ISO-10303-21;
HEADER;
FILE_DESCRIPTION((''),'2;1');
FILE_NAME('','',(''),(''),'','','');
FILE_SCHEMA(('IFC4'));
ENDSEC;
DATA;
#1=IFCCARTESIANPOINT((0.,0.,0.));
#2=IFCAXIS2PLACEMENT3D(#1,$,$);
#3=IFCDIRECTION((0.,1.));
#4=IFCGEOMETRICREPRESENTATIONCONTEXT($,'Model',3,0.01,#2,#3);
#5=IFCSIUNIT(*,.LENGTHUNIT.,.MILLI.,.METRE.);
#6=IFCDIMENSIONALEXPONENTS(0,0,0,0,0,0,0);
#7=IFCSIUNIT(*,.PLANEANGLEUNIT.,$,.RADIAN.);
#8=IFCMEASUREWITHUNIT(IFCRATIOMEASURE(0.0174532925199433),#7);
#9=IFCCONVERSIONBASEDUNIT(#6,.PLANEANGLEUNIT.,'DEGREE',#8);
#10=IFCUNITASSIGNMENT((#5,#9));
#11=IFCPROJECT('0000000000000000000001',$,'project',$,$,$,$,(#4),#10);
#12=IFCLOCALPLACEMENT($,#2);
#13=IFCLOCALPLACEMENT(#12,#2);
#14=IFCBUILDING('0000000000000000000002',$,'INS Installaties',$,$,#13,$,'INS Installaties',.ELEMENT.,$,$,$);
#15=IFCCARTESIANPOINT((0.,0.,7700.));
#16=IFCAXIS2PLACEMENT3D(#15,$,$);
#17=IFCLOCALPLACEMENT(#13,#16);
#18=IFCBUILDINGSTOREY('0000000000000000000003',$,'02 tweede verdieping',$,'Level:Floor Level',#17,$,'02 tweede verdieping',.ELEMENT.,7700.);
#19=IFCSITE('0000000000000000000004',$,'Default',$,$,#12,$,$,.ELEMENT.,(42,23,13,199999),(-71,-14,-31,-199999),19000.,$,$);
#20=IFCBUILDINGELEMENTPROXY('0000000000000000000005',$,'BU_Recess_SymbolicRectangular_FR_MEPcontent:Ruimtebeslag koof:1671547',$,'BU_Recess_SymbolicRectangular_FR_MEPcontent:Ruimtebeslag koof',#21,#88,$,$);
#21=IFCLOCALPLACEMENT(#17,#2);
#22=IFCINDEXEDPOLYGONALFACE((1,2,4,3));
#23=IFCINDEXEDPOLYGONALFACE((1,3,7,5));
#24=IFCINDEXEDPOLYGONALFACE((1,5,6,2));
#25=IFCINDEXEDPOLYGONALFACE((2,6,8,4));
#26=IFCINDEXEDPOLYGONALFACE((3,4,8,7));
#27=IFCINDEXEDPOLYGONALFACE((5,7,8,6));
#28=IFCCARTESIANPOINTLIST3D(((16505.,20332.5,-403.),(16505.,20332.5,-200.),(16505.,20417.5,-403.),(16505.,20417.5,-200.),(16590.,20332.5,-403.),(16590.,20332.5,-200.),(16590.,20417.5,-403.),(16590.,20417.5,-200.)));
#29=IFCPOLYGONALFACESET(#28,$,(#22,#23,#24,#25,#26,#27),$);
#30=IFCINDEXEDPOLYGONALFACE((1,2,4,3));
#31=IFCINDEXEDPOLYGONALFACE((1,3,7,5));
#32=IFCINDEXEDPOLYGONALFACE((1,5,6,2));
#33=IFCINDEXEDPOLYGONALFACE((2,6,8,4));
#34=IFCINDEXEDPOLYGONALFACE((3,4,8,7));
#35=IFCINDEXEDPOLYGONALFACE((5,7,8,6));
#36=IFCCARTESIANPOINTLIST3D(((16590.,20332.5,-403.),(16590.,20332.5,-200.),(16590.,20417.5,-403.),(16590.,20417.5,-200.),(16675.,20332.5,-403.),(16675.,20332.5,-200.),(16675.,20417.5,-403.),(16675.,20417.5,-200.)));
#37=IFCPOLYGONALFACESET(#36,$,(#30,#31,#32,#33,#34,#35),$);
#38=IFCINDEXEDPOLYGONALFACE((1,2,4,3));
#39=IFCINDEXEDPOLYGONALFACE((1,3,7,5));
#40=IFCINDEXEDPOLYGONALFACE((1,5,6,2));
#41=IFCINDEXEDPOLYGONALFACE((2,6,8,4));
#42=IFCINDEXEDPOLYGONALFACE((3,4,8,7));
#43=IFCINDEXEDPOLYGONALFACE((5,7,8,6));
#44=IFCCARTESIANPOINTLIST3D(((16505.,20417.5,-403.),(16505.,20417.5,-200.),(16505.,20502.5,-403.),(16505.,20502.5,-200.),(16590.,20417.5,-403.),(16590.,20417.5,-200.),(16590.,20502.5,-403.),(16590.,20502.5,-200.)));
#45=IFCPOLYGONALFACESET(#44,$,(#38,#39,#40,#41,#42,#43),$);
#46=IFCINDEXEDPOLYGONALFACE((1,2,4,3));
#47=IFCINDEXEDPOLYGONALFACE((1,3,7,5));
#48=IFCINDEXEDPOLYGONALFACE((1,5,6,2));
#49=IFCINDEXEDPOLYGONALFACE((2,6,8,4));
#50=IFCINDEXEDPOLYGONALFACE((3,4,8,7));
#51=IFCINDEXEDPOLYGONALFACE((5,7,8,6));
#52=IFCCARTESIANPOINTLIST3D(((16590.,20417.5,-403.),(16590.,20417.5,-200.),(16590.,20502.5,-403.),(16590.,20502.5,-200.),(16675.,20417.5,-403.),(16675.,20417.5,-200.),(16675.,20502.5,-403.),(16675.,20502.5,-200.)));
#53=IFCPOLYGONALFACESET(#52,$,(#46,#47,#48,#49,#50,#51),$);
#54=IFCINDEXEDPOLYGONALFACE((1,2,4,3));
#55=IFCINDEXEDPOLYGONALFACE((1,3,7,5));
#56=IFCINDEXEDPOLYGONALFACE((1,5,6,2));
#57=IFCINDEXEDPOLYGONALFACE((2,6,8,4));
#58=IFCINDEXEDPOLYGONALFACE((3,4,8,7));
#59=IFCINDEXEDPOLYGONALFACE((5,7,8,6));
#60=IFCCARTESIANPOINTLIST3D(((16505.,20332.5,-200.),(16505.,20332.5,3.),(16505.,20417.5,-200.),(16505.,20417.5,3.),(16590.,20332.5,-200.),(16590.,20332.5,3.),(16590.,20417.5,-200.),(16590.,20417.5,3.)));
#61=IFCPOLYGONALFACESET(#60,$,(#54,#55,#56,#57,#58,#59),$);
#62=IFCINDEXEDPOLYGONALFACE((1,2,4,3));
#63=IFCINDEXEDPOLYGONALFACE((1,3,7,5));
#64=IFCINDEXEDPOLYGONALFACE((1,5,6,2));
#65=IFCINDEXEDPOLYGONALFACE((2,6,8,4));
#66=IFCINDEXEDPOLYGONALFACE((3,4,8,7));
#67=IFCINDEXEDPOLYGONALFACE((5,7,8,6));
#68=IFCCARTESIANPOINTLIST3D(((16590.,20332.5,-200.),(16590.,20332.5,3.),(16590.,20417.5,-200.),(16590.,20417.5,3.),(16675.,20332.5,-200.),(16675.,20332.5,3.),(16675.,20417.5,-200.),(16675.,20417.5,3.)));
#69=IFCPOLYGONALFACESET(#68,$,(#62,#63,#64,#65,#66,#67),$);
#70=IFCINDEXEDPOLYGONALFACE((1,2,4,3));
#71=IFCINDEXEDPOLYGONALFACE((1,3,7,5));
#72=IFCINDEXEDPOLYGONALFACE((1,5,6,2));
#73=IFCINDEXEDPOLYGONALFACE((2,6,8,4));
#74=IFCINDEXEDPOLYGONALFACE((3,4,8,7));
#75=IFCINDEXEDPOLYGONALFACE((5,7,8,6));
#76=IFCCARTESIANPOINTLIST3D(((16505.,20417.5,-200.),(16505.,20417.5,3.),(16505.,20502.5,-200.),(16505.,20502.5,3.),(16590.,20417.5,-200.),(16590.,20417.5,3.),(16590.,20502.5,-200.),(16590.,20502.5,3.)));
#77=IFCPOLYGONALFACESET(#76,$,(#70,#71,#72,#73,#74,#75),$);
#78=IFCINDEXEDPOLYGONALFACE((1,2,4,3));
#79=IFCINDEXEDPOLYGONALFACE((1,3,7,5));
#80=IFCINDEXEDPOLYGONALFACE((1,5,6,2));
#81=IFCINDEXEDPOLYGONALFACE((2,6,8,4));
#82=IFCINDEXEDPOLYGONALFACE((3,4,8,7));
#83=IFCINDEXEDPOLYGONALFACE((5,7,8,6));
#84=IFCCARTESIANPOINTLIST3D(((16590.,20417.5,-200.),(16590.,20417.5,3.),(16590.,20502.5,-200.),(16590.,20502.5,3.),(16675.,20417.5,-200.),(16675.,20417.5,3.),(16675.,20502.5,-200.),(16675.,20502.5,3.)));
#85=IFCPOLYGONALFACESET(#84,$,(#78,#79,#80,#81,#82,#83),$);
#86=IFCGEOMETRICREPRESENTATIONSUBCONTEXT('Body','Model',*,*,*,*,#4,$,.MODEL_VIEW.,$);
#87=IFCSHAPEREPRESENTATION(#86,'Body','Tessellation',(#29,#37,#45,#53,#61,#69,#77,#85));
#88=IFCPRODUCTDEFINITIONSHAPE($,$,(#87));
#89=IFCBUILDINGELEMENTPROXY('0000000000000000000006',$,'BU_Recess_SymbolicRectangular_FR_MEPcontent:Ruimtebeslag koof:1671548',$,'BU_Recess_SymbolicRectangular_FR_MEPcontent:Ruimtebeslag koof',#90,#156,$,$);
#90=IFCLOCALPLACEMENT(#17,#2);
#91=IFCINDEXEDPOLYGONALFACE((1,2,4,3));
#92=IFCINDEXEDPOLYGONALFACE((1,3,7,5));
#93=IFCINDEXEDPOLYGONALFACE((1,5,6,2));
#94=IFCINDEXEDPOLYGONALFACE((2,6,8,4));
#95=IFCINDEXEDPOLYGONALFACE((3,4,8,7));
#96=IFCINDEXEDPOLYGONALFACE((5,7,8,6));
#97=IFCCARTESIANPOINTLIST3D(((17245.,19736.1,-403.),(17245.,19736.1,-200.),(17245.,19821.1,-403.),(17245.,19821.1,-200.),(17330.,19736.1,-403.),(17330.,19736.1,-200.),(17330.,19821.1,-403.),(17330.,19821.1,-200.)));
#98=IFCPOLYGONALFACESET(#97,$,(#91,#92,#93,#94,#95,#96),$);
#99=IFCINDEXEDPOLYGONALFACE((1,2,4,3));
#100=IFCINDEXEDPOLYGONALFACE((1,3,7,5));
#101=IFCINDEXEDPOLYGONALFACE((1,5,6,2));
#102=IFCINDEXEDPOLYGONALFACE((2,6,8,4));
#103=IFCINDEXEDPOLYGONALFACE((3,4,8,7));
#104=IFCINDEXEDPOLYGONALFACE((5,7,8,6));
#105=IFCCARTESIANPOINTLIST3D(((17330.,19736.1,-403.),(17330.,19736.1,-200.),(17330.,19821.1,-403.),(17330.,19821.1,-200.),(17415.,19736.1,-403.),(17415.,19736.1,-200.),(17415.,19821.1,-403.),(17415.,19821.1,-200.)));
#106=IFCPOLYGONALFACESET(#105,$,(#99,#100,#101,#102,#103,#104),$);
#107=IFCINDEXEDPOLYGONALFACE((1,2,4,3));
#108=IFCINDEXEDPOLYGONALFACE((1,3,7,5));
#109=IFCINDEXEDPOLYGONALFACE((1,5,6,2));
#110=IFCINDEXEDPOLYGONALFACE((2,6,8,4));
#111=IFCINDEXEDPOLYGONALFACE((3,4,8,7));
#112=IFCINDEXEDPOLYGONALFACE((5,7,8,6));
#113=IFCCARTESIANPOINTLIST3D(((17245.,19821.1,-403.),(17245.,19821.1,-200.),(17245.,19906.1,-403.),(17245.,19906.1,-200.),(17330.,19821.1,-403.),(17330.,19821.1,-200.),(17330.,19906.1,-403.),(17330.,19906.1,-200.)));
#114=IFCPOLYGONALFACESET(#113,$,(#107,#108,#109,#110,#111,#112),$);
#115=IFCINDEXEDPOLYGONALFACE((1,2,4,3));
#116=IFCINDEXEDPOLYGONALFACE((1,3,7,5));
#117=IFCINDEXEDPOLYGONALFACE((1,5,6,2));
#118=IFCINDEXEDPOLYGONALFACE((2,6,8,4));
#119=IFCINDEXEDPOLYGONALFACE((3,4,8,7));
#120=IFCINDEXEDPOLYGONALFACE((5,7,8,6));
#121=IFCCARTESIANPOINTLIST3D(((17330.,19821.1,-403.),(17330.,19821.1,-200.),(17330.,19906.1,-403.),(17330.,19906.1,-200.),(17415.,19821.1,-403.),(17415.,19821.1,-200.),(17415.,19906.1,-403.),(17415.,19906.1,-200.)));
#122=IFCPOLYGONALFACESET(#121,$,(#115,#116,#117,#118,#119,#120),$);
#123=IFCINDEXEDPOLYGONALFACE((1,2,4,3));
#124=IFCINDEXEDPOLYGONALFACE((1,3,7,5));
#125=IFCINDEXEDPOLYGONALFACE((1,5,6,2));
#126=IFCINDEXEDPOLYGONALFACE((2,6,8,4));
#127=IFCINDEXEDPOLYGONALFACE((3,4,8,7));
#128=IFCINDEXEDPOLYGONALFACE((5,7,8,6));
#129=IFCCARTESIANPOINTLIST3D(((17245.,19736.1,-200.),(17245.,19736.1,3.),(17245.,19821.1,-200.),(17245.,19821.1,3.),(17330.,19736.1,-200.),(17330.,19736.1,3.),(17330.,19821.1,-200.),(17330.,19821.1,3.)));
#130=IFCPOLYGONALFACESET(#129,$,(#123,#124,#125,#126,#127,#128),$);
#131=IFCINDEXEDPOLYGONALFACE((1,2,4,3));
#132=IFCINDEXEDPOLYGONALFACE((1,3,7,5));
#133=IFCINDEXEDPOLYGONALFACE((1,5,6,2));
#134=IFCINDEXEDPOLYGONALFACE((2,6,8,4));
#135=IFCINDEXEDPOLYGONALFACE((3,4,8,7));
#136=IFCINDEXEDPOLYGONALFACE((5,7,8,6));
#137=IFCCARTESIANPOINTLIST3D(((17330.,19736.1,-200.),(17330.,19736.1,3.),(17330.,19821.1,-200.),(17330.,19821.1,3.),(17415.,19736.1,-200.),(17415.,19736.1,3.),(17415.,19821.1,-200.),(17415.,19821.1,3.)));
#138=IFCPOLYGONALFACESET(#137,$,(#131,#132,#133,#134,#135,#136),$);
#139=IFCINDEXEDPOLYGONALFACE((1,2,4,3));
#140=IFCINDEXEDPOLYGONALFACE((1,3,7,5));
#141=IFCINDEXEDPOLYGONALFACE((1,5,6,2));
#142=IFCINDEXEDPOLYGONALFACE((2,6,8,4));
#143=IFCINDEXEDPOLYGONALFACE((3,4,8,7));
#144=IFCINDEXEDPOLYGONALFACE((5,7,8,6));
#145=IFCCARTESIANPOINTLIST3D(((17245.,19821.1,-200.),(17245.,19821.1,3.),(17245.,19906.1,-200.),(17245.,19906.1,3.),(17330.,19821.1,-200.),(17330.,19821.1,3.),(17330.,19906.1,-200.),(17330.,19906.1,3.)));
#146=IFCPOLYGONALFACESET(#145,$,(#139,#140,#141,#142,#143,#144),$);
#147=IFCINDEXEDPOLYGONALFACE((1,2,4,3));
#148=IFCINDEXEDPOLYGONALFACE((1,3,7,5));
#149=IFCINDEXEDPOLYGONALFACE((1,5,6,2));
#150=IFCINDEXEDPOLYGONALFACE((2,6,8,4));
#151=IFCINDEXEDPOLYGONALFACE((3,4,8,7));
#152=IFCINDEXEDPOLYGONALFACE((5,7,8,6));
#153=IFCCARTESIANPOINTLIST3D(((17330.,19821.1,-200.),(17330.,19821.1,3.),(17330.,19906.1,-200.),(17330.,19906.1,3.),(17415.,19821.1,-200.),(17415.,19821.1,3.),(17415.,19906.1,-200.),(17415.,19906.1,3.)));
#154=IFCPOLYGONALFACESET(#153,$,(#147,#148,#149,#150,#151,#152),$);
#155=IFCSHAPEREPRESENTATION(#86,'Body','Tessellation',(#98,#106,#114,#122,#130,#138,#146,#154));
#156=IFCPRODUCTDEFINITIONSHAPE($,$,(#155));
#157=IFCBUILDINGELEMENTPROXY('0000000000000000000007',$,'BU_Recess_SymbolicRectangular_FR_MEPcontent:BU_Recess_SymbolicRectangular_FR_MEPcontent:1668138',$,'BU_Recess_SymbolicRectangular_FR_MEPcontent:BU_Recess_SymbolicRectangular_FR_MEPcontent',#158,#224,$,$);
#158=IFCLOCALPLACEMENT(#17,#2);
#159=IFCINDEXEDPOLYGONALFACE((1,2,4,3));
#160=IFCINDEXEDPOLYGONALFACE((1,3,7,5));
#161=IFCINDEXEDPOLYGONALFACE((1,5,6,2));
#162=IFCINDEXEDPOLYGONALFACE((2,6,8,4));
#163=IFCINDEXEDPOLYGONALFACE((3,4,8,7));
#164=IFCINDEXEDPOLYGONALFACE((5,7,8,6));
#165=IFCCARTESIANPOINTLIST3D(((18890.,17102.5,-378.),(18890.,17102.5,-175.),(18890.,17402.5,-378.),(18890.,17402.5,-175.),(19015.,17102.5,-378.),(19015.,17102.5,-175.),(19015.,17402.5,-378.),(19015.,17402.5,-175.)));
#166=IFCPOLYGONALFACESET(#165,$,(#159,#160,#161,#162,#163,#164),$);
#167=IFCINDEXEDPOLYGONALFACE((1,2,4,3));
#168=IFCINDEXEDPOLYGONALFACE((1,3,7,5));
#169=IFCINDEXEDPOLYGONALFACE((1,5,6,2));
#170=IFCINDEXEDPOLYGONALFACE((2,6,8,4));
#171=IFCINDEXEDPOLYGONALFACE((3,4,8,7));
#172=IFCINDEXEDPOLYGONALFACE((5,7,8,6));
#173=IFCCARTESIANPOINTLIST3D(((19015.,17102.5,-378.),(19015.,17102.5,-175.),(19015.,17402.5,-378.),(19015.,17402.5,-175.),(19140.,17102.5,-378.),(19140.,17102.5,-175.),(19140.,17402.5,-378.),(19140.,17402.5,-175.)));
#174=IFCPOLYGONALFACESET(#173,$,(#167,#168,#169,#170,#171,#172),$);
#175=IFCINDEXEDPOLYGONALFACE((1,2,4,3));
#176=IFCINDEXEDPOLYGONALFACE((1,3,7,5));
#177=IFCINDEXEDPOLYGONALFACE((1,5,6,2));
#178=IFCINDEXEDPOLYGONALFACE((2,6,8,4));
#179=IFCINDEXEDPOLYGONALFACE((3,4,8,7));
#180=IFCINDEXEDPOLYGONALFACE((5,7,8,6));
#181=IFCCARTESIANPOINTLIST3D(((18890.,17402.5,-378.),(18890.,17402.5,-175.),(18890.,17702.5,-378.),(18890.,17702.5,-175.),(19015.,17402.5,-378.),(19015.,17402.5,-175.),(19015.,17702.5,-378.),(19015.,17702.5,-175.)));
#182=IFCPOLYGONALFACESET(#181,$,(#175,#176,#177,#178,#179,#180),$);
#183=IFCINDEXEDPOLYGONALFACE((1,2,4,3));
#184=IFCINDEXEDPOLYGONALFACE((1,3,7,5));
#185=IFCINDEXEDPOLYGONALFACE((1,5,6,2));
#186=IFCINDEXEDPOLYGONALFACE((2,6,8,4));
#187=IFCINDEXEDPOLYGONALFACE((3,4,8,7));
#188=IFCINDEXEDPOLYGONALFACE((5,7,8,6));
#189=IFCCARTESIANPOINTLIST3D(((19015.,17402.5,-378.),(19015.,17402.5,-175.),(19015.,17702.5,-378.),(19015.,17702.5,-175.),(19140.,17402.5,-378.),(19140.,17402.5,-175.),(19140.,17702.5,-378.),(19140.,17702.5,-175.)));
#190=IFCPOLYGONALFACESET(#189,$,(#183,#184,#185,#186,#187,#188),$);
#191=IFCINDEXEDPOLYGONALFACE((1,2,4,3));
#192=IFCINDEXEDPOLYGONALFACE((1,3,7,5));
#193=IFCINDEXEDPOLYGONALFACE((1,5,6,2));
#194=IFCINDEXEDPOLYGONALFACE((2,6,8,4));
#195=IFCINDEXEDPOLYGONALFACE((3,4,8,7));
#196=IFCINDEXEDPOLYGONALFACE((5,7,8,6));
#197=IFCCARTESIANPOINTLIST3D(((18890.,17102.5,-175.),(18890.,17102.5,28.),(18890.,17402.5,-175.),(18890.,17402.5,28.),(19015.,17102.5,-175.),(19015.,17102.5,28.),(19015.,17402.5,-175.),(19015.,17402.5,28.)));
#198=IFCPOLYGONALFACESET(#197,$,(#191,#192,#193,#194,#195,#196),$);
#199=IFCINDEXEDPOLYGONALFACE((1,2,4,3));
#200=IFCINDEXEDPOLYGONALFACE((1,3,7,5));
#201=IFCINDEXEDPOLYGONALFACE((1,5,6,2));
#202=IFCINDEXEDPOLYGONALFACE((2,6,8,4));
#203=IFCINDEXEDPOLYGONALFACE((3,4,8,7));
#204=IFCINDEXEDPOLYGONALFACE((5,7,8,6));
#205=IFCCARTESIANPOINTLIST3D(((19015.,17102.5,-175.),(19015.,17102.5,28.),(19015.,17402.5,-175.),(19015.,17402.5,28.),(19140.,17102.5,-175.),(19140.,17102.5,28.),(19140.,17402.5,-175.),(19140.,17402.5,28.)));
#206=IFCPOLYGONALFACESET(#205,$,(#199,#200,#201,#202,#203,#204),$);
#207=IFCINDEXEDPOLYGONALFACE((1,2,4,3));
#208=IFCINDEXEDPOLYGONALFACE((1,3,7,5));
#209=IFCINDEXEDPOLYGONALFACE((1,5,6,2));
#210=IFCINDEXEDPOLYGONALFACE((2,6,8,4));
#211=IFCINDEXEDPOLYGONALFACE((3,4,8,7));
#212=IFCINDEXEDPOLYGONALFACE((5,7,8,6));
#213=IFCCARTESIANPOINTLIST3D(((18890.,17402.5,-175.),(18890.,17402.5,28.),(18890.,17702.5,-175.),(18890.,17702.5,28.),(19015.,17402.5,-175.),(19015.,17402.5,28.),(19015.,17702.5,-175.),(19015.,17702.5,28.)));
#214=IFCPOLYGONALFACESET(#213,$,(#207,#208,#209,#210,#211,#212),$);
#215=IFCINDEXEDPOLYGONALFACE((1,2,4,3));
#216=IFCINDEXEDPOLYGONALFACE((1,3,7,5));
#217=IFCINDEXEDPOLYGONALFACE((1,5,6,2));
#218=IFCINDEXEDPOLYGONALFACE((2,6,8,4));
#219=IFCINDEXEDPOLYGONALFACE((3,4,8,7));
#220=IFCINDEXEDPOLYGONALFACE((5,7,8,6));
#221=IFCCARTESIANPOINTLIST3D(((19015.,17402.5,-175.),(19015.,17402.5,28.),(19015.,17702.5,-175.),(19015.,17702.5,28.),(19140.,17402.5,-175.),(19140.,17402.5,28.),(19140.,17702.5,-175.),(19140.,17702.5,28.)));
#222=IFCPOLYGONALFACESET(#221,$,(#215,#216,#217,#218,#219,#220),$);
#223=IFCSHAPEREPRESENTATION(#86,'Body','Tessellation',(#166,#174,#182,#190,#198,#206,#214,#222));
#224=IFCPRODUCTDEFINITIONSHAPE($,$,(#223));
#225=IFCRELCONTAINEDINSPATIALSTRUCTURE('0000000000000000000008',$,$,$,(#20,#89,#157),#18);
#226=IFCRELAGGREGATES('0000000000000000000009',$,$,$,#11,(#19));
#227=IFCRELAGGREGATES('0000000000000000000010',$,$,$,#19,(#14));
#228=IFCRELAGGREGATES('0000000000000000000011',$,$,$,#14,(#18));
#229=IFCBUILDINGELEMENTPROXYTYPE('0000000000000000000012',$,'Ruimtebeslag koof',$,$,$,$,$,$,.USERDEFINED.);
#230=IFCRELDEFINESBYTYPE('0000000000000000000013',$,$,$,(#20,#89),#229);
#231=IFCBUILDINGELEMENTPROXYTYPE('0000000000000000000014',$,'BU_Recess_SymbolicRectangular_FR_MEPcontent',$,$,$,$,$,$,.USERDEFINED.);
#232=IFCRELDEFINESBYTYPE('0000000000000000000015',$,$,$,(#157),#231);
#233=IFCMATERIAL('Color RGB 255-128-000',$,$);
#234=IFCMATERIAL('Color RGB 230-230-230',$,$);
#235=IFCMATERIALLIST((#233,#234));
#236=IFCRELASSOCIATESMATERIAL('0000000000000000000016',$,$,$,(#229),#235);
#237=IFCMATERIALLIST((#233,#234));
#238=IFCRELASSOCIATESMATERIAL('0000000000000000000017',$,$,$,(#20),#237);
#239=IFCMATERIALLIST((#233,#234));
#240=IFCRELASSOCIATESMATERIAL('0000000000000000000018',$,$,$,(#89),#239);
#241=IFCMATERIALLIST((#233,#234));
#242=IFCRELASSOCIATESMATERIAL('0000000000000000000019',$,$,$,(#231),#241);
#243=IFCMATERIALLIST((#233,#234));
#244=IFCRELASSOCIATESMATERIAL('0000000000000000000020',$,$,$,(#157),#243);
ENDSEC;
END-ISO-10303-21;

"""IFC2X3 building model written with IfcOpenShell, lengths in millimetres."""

from ifc_helpers import new_model, entity, si_unit, converted_unit, direction, frame, frame_2d, origin, origin_2d_with_axis, place, context, subcontext, project, spatial, rectangle, extrude, source, transform, mapped, material, material_list, type_object, type_shapes, element, save


model = new_model("IFC2X3")

# Units and contexts
model_context = context("Model", 3, precision=0.01, world=origin(), true_north=direction((0.0, 1.0)))
body_context = subcontext(model_context, "Body", "Model", "MODEL_VIEW")
ifc_project = project(units=[si_unit("LENGTHUNIT", "METRE", prefix="MILLI"), converted_unit("PLANEANGLEUNIT", "DEGREE", entity("IfcRatioMeasure", 0.0174532925199433), si_unit("PLANEANGLEUNIT", "RADIAN"), dimensions=[0, 0, 0, 0, 0, 0, 0])], contexts=[model_context])

# Site, building, storey
site_placement = place(None, origin())
site = spatial("IfcSite", under=ifc_project, at=site_placement, Name="Default", CompositionType="ELEMENT", RefLatitude=(42, 23, 13, 199999), RefLongitude=(-71, -14, -31, -199999), RefElevation=19000.0)
building_placement = place(site_placement, origin())
building = spatial("IfcBuilding", under=site, at=building_placement, Name="INS Installaties", LongName="INS Installaties", CompositionType="ELEMENT")
storey_placement = place(building_placement, frame((0.0, 0.0, 7700.0)))
storey = spatial("IfcBuildingStorey", under=building, at=storey_placement, Name="02 tweede verdieping", ObjectType="Level:Floor Level", LongName="02 tweede verdieping", CompositionType="ELEMENT", Elevation=7700.0)

# Building element proxies
ifc_material_1 = material(Name="Color RGB 255-128-000")
ifc_material_2 = material(Name="Color RGB 230-230-230")
ifc_material_list_1 = material_list([ifc_material_1, ifc_material_2])
building_element_proxy_type_1 = type_object("IfcBuildingElementProxyType", Name="Ruimtebeslag koof", PredefinedType="USERDEFINED", material=ifc_material_list_1)
shared_shape_1 = source(origin(), body_context, "Body", "SweptSolid", [
    extrude(rectangle(XDim=85.0, YDim=85.0, at=origin_2d_with_axis()), frame((42.5, 42.5, -403.0), z_axis=(0.0, 0.0, 1.0), x_axis=(0.0, -1.0, 0.0)), (0.0, 0.0, 1.0), 203.0),
    extrude(rectangle(XDim=85.0, YDim=85.0, at=origin_2d_with_axis()), frame((-42.5, 42.5, -403.0), z_axis=(0.0, 0.0, 1.0), x_axis=(-1.0, 0.0, 0.0)), (0.0, 0.0, 1.0), 203.0),
    extrude(rectangle(XDim=85.0, YDim=85.0, at=frame_2d((0.0, 0.0), x_axis=(1.0, 0.0))), frame((42.5, -42.5, -403.0)), (0.0, 0.0, 1.0), 203.0),
    extrude(rectangle(XDim=85.0, YDim=85.0, at=origin_2d_with_axis()), frame((-42.5, -42.5, -403.0), z_axis=(0.0, 0.0, 1.0), x_axis=(0.0, 1.0, 0.0)), (0.0, 0.0, 1.0), 203.0),
    extrude(rectangle(XDim=85.0, YDim=85.0, at=origin_2d_with_axis()), frame((42.5, 42.5, -200.0), z_axis=(0.0, 0.0, 1.0), x_axis=(0.0, -1.0, 0.0)), (0.0, 0.0, 1.0), 203.0),
    extrude(rectangle(XDim=85.0, YDim=85.0, at=frame_2d((0.0, 0.0), x_axis=(1.0, 0.0))), frame((-42.5, 42.5, -200.0), z_axis=(0.0, 0.0, 1.0), x_axis=(-1.0, 0.0, 0.0)), (0.0, 0.0, 1.0), 203.0),
    extrude(rectangle(XDim=85.0, YDim=85.0, at=frame_2d((0.0, 0.0), x_axis=(1.0, 0.0))), frame((42.5, -42.5, -200.0)), (0.0, 0.0, 1.0), 203.0),
    extrude(rectangle(XDim=85.0, YDim=85.0, at=origin_2d_with_axis()), frame((-42.5, -42.5, -200.0), z_axis=(0.0, 0.0, 1.0), x_axis=(0.0, 1.0, 0.0)), (0.0, 0.0, 1.0), 203.0),
])
type_shapes(building_element_proxy_type_1, [shared_shape_1])
ifc_material_list_2 = material_list([ifc_material_1, ifc_material_2])
proxy_1_placement = place(storey_placement, frame((16590.0, 20417.5, 0.0), z_axis=(0.0, 0.0, 1.0), x_axis=(-1.0, 0.0, 0.0)))
element("IfcBuildingElementProxy", 1, at=proxy_1_placement, inside=storey, type_object=building_element_proxy_type_1, material=ifc_material_list_2, Name="BU_Recess_SymbolicRectangular_FR_MEPcontent:Ruimtebeslag koof:1671547", ObjectType="BU_Recess_SymbolicRectangular_FR_MEPcontent:Ruimtebeslag koof", context=body_context, shape_type="MappedRepresentation", body=[
    mapped(shared_shape_1, transform((0.0, 0.0, 0.0), scale=1.0)),
])
ifc_material_list_3 = material_list([ifc_material_1, ifc_material_2])
proxy_2_placement = place(storey_placement, frame((17330.0, 19821.1, 0.0), z_axis=(0.0, 0.0, 1.0), x_axis=(-1.0, 0.0, 0.0)))
element("IfcBuildingElementProxy", 2, at=proxy_2_placement, inside=storey, type_object=building_element_proxy_type_1, material=ifc_material_list_3, Name="BU_Recess_SymbolicRectangular_FR_MEPcontent:Ruimtebeslag koof:1671548", ObjectType="BU_Recess_SymbolicRectangular_FR_MEPcontent:Ruimtebeslag koof", context=body_context, shape_type="MappedRepresentation", body=[
    mapped(shared_shape_1, transform((0.0, 0.0, 0.0), scale=1.0)),
])
ifc_material_list_4 = material_list([ifc_material_1, ifc_material_2])
ifc_material_list_5 = material_list([ifc_material_1, ifc_material_2])
building_element_proxy_type_2 = type_object("IfcBuildingElementProxyType", Name="BU_Recess_SymbolicRectangular_FR_MEPcontent", PredefinedType="USERDEFINED", material=ifc_material_list_5)
shared_shape_2 = source(origin(), body_context, "Body", "SweptSolid", [
    extrude(rectangle(XDim=300.0, YDim=125.0, at=origin_2d_with_axis()), frame((62.5, 150.0, -403.0), z_axis=(0.0, 0.0, 1.0), x_axis=(0.0, -1.0, 0.0)), (0.0, 0.0, 1.0), 203.0),
    extrude(rectangle(XDim=125.0, YDim=300.0, at=origin_2d_with_axis()), frame((-62.5, 150.0, -403.0), z_axis=(0.0, 0.0, 1.0), x_axis=(-1.0, 0.0, 0.0)), (0.0, 0.0, 1.0), 203.0),
    extrude(rectangle(XDim=125.0, YDim=300.0, at=origin_2d_with_axis()), frame((62.5, -150.0, -403.0)), (0.0, 0.0, 1.0), 203.0),
    extrude(rectangle(XDim=300.0, YDim=125.0, at=origin_2d_with_axis()), frame((-62.5, -150.0, -403.0), z_axis=(0.0, 0.0, 1.0), x_axis=(0.0, 1.0, 0.0)), (0.0, 0.0, 1.0), 203.0),
    extrude(rectangle(XDim=300.0, YDim=125.0, at=origin_2d_with_axis()), frame((62.5, 150.0, -200.0), z_axis=(0.0, 0.0, 1.0), x_axis=(0.0, -1.0, 0.0)), (0.0, 0.0, 1.0), 203.0),
    extrude(rectangle(XDim=125.0, YDim=300.0, at=frame_2d((0.0, 0.0), x_axis=(1.0, 0.0))), frame((-62.5, 150.0, -200.0), z_axis=(0.0, 0.0, 1.0), x_axis=(-1.0, 0.0, 0.0)), (0.0, 0.0, 1.0), 203.0),
    extrude(rectangle(XDim=125.0, YDim=300.0, at=frame_2d((0.0, 0.0), x_axis=(1.0, 0.0))), frame((62.5, -150.0, -200.0)), (0.0, 0.0, 1.0), 203.0),
    extrude(rectangle(XDim=300.0, YDim=125.0, at=origin_2d_with_axis()), frame((-62.5, -150.0, -200.0), z_axis=(0.0, 0.0, 1.0), x_axis=(0.0, 1.0, 0.0)), (0.0, 0.0, 1.0), 203.0),
])
type_shapes(building_element_proxy_type_2, [shared_shape_2])
proxy_3_placement = place(storey_placement, frame((19015.0, 17402.5, 25.0), z_axis=(0.0, 0.0, 1.0), x_axis=(-1.0, 0.0, 0.0)))
element("IfcBuildingElementProxy", 3, at=proxy_3_placement, inside=storey, type_object=building_element_proxy_type_2, material=ifc_material_list_4, Name="BU_Recess_SymbolicRectangular_FR_MEPcontent:BU_Recess_SymbolicRectangular_FR_MEPcontent:1668138", ObjectType="BU_Recess_SymbolicRectangular_FR_MEPcontent:BU_Recess_SymbolicRectangular_FR_MEPcontent", context=body_context, shape_type="MappedRepresentation", body=[
    mapped(shared_shape_2, transform((0.0, 0.0, 0.0), scale=1.0)),
])

save(model, "model.ifc")
